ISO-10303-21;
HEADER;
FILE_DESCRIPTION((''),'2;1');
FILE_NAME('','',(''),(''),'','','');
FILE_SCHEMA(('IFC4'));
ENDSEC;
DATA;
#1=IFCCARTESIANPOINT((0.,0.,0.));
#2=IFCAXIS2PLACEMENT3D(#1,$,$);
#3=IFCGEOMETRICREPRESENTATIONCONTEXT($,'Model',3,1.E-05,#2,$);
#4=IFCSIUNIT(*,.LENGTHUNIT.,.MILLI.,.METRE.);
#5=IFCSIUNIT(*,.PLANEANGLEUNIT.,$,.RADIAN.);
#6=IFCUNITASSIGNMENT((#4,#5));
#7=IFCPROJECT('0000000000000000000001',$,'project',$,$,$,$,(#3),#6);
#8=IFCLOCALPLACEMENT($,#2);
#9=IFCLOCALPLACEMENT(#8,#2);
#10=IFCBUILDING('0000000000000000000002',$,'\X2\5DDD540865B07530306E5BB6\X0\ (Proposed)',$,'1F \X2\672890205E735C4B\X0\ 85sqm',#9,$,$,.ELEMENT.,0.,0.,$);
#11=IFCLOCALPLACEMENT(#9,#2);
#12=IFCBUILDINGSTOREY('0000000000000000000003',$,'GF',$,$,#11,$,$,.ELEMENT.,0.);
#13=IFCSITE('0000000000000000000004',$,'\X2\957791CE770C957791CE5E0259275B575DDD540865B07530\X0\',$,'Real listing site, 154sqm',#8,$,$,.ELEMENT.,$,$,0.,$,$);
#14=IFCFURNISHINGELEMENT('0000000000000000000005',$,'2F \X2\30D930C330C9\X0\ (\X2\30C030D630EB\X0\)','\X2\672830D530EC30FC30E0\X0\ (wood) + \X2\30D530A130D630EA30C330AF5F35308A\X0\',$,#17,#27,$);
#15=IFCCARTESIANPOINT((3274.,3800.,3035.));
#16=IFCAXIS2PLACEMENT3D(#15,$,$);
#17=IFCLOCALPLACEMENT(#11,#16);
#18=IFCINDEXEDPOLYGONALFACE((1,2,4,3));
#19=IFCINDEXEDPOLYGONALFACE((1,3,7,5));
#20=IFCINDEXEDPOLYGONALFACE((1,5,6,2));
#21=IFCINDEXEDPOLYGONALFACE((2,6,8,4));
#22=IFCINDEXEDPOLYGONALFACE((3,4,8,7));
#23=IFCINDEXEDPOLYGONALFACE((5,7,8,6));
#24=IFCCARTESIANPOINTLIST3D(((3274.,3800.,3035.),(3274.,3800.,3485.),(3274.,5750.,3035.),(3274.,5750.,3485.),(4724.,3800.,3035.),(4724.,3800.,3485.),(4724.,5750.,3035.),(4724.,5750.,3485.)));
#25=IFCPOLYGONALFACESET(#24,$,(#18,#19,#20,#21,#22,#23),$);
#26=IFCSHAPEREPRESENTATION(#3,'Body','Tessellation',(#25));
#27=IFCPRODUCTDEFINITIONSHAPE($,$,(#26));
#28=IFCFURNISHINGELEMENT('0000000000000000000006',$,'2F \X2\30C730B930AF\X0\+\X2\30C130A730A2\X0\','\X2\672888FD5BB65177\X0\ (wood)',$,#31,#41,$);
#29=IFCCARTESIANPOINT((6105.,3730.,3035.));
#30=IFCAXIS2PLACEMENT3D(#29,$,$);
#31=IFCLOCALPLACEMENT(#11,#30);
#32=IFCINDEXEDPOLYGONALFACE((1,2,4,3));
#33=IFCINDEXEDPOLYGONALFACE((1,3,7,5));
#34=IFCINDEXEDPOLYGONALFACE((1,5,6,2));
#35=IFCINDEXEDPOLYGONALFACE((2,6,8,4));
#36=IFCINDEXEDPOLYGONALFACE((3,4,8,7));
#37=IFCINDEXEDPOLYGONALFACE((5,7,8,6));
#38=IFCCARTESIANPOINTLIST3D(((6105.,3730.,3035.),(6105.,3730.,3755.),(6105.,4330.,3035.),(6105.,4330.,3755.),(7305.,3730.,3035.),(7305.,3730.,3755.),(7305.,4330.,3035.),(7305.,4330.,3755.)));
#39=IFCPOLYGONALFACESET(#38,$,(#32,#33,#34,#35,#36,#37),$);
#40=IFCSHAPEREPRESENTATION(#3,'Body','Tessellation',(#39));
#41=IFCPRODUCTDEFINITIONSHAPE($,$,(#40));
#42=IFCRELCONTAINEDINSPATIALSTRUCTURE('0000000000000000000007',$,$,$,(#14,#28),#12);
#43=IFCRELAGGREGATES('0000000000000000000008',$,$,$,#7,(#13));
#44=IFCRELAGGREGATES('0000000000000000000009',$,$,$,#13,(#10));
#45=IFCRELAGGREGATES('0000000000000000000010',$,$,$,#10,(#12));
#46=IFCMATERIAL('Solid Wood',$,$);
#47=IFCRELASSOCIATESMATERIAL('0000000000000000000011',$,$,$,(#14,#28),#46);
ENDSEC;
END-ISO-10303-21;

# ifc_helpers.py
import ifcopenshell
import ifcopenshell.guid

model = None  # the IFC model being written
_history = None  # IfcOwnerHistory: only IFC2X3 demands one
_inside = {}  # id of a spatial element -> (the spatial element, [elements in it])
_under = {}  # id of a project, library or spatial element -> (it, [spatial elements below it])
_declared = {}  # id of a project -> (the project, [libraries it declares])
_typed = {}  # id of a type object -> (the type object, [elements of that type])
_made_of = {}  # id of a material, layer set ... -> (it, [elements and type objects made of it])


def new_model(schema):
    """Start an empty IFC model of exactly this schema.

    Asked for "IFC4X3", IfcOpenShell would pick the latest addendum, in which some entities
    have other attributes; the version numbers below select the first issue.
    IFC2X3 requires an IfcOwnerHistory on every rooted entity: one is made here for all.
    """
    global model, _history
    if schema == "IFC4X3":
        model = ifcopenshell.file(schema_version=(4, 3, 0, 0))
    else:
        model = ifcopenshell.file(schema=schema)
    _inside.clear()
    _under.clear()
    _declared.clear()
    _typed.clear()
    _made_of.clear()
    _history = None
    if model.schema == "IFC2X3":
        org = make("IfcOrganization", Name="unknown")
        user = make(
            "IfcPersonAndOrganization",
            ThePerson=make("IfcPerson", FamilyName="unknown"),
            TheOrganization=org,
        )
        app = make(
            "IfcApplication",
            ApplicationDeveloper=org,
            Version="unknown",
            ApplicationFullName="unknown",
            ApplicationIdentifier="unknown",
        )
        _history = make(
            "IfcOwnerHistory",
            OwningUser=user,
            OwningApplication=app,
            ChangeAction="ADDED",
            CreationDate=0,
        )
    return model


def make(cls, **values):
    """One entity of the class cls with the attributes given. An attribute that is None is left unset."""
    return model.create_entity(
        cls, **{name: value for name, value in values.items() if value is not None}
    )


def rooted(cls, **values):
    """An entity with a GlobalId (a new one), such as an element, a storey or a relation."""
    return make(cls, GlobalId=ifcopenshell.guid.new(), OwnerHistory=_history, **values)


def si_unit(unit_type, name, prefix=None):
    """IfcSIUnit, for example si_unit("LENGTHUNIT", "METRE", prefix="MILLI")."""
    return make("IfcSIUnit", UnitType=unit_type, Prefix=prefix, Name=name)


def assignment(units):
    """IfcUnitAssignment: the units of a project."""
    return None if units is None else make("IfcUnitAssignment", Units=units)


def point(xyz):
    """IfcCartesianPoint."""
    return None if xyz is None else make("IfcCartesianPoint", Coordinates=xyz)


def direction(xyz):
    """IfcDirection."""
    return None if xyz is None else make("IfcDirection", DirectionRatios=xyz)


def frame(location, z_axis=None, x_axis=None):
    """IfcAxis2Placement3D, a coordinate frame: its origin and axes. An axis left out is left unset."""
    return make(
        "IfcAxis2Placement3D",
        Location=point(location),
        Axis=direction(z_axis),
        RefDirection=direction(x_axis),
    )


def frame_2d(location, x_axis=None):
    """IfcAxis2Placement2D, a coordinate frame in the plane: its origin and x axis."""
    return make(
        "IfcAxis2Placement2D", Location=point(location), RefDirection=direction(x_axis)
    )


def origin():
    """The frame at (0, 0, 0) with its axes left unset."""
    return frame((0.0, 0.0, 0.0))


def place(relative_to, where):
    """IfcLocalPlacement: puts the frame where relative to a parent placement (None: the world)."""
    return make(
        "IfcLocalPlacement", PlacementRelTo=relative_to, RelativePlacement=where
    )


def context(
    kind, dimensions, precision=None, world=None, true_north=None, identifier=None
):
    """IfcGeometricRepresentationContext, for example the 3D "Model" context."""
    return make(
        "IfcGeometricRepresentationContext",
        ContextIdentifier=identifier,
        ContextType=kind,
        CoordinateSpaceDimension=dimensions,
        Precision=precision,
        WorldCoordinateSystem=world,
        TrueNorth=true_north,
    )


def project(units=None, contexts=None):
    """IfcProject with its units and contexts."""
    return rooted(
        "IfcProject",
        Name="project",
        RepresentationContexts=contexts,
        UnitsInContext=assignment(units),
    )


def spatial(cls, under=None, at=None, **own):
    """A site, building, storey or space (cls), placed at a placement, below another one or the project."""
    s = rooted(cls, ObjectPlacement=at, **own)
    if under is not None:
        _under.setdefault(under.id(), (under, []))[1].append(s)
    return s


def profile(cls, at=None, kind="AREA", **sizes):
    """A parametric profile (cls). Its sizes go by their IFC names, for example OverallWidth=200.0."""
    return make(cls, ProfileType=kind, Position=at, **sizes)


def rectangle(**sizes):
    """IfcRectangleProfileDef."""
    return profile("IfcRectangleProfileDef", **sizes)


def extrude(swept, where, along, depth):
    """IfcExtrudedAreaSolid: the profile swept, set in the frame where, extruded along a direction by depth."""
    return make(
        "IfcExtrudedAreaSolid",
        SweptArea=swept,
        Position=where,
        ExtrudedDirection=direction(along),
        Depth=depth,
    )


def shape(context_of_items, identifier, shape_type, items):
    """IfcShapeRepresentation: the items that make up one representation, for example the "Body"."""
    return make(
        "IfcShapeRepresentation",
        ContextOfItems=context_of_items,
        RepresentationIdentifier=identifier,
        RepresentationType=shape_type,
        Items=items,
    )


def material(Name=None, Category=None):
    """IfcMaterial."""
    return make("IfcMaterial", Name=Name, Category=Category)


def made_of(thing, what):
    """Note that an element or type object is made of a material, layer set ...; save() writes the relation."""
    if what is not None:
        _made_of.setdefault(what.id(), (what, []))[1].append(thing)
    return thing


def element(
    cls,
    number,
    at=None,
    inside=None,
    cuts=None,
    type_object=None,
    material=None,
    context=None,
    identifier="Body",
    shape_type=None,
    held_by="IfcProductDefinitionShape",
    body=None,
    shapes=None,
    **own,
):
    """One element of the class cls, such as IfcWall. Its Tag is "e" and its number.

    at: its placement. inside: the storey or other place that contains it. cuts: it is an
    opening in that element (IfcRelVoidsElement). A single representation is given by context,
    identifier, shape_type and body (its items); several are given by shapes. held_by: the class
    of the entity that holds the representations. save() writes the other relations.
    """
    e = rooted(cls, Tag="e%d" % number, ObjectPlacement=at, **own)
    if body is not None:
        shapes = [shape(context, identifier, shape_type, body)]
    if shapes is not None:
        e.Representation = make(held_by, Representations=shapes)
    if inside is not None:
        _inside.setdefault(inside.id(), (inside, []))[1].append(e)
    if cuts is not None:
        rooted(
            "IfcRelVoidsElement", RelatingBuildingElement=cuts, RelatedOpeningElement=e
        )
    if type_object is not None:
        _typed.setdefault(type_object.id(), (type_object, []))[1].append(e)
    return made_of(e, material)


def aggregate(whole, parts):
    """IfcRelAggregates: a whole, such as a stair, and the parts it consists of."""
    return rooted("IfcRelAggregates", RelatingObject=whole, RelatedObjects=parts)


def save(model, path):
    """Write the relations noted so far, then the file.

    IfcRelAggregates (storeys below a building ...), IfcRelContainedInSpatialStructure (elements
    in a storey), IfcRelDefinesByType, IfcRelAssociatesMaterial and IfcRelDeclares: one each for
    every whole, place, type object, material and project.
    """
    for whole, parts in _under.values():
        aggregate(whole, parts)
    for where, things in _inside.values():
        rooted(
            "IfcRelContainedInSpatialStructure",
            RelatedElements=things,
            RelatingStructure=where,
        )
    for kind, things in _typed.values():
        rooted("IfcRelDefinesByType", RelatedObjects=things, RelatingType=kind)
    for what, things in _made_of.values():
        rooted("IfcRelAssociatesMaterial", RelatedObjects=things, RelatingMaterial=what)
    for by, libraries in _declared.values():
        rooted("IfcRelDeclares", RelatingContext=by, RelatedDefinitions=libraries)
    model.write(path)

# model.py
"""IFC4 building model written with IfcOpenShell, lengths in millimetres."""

from ifc_helpers import new_model, si_unit, frame, frame_2d, origin, place, context, project, spatial, rectangle, extrude, material, element, save


model = new_model("IFC4")

# Units and contexts
model_context = context("Model", 3, precision=1e-05, world=origin())
ifc_project = project(units=[si_unit("LENGTHUNIT", "METRE", prefix="MILLI"), si_unit("PLANEANGLEUNIT", "RADIAN")], contexts=[model_context])

# Site, building, storey
site_placement = place(None, origin())
site = spatial("IfcSite", under=ifc_project, at=site_placement, Name="長野県長野市大字川合新田", ObjectType="Real listing site, 154sqm", CompositionType="ELEMENT", RefElevation=0.0)
building_placement = place(site_placement, origin())
building = spatial("IfcBuilding", under=site, at=building_placement, Name="川合新田の家 (Proposed)", ObjectType="1F 木造平屋 85sqm", CompositionType="ELEMENT", ElevationOfRefHeight=0.0, ElevationOfTerrain=0.0)
storey_placement = place(building_placement, origin())
storey = spatial("IfcBuildingStorey", under=building, at=storey_placement, Name="GF", CompositionType="ELEMENT", Elevation=0.0)

# Shared definitions
ifc_material_1 = material(Name="Solid Wood")

# Furnishing elements
furnishing_1_placement = place(storey_placement, frame((3274.0, 3800.0, 3035.0)))
element("IfcFurnishingElement", 1, at=furnishing_1_placement, inside=storey, material=ifc_material_1, Name="2F ベッド (ダブル)", Description="木フレーム (wood) + ファブリック張り", context=model_context, shape_type="SweptSolid", body=[
    extrude(rectangle(XDim=1450.0, YDim=1950.0, at=frame_2d((725.0, 975.0))), frame((3274.0, 3800.0, 3035.0)), (0.0, 0.0, 1.0), 450.0),
])
furnishing_2_placement = place(storey_placement, frame((6105.0, 3730.0, 3035.0)))
element("IfcFurnishingElement", 2, at=furnishing_2_placement, inside=storey, material=ifc_material_1, Name="2F デスク+チェア", Description="木製家具 (wood)", context=model_context, shape_type="SweptSolid", body=[
    extrude(rectangle(XDim=1200.0, YDim=600.0, at=frame_2d((600.0, 300.0))), frame((6105.0, 3730.0, 3035.0)), (0.0, 0.0, 1.0), 720.0),
])

save(model, "model.ifc")
